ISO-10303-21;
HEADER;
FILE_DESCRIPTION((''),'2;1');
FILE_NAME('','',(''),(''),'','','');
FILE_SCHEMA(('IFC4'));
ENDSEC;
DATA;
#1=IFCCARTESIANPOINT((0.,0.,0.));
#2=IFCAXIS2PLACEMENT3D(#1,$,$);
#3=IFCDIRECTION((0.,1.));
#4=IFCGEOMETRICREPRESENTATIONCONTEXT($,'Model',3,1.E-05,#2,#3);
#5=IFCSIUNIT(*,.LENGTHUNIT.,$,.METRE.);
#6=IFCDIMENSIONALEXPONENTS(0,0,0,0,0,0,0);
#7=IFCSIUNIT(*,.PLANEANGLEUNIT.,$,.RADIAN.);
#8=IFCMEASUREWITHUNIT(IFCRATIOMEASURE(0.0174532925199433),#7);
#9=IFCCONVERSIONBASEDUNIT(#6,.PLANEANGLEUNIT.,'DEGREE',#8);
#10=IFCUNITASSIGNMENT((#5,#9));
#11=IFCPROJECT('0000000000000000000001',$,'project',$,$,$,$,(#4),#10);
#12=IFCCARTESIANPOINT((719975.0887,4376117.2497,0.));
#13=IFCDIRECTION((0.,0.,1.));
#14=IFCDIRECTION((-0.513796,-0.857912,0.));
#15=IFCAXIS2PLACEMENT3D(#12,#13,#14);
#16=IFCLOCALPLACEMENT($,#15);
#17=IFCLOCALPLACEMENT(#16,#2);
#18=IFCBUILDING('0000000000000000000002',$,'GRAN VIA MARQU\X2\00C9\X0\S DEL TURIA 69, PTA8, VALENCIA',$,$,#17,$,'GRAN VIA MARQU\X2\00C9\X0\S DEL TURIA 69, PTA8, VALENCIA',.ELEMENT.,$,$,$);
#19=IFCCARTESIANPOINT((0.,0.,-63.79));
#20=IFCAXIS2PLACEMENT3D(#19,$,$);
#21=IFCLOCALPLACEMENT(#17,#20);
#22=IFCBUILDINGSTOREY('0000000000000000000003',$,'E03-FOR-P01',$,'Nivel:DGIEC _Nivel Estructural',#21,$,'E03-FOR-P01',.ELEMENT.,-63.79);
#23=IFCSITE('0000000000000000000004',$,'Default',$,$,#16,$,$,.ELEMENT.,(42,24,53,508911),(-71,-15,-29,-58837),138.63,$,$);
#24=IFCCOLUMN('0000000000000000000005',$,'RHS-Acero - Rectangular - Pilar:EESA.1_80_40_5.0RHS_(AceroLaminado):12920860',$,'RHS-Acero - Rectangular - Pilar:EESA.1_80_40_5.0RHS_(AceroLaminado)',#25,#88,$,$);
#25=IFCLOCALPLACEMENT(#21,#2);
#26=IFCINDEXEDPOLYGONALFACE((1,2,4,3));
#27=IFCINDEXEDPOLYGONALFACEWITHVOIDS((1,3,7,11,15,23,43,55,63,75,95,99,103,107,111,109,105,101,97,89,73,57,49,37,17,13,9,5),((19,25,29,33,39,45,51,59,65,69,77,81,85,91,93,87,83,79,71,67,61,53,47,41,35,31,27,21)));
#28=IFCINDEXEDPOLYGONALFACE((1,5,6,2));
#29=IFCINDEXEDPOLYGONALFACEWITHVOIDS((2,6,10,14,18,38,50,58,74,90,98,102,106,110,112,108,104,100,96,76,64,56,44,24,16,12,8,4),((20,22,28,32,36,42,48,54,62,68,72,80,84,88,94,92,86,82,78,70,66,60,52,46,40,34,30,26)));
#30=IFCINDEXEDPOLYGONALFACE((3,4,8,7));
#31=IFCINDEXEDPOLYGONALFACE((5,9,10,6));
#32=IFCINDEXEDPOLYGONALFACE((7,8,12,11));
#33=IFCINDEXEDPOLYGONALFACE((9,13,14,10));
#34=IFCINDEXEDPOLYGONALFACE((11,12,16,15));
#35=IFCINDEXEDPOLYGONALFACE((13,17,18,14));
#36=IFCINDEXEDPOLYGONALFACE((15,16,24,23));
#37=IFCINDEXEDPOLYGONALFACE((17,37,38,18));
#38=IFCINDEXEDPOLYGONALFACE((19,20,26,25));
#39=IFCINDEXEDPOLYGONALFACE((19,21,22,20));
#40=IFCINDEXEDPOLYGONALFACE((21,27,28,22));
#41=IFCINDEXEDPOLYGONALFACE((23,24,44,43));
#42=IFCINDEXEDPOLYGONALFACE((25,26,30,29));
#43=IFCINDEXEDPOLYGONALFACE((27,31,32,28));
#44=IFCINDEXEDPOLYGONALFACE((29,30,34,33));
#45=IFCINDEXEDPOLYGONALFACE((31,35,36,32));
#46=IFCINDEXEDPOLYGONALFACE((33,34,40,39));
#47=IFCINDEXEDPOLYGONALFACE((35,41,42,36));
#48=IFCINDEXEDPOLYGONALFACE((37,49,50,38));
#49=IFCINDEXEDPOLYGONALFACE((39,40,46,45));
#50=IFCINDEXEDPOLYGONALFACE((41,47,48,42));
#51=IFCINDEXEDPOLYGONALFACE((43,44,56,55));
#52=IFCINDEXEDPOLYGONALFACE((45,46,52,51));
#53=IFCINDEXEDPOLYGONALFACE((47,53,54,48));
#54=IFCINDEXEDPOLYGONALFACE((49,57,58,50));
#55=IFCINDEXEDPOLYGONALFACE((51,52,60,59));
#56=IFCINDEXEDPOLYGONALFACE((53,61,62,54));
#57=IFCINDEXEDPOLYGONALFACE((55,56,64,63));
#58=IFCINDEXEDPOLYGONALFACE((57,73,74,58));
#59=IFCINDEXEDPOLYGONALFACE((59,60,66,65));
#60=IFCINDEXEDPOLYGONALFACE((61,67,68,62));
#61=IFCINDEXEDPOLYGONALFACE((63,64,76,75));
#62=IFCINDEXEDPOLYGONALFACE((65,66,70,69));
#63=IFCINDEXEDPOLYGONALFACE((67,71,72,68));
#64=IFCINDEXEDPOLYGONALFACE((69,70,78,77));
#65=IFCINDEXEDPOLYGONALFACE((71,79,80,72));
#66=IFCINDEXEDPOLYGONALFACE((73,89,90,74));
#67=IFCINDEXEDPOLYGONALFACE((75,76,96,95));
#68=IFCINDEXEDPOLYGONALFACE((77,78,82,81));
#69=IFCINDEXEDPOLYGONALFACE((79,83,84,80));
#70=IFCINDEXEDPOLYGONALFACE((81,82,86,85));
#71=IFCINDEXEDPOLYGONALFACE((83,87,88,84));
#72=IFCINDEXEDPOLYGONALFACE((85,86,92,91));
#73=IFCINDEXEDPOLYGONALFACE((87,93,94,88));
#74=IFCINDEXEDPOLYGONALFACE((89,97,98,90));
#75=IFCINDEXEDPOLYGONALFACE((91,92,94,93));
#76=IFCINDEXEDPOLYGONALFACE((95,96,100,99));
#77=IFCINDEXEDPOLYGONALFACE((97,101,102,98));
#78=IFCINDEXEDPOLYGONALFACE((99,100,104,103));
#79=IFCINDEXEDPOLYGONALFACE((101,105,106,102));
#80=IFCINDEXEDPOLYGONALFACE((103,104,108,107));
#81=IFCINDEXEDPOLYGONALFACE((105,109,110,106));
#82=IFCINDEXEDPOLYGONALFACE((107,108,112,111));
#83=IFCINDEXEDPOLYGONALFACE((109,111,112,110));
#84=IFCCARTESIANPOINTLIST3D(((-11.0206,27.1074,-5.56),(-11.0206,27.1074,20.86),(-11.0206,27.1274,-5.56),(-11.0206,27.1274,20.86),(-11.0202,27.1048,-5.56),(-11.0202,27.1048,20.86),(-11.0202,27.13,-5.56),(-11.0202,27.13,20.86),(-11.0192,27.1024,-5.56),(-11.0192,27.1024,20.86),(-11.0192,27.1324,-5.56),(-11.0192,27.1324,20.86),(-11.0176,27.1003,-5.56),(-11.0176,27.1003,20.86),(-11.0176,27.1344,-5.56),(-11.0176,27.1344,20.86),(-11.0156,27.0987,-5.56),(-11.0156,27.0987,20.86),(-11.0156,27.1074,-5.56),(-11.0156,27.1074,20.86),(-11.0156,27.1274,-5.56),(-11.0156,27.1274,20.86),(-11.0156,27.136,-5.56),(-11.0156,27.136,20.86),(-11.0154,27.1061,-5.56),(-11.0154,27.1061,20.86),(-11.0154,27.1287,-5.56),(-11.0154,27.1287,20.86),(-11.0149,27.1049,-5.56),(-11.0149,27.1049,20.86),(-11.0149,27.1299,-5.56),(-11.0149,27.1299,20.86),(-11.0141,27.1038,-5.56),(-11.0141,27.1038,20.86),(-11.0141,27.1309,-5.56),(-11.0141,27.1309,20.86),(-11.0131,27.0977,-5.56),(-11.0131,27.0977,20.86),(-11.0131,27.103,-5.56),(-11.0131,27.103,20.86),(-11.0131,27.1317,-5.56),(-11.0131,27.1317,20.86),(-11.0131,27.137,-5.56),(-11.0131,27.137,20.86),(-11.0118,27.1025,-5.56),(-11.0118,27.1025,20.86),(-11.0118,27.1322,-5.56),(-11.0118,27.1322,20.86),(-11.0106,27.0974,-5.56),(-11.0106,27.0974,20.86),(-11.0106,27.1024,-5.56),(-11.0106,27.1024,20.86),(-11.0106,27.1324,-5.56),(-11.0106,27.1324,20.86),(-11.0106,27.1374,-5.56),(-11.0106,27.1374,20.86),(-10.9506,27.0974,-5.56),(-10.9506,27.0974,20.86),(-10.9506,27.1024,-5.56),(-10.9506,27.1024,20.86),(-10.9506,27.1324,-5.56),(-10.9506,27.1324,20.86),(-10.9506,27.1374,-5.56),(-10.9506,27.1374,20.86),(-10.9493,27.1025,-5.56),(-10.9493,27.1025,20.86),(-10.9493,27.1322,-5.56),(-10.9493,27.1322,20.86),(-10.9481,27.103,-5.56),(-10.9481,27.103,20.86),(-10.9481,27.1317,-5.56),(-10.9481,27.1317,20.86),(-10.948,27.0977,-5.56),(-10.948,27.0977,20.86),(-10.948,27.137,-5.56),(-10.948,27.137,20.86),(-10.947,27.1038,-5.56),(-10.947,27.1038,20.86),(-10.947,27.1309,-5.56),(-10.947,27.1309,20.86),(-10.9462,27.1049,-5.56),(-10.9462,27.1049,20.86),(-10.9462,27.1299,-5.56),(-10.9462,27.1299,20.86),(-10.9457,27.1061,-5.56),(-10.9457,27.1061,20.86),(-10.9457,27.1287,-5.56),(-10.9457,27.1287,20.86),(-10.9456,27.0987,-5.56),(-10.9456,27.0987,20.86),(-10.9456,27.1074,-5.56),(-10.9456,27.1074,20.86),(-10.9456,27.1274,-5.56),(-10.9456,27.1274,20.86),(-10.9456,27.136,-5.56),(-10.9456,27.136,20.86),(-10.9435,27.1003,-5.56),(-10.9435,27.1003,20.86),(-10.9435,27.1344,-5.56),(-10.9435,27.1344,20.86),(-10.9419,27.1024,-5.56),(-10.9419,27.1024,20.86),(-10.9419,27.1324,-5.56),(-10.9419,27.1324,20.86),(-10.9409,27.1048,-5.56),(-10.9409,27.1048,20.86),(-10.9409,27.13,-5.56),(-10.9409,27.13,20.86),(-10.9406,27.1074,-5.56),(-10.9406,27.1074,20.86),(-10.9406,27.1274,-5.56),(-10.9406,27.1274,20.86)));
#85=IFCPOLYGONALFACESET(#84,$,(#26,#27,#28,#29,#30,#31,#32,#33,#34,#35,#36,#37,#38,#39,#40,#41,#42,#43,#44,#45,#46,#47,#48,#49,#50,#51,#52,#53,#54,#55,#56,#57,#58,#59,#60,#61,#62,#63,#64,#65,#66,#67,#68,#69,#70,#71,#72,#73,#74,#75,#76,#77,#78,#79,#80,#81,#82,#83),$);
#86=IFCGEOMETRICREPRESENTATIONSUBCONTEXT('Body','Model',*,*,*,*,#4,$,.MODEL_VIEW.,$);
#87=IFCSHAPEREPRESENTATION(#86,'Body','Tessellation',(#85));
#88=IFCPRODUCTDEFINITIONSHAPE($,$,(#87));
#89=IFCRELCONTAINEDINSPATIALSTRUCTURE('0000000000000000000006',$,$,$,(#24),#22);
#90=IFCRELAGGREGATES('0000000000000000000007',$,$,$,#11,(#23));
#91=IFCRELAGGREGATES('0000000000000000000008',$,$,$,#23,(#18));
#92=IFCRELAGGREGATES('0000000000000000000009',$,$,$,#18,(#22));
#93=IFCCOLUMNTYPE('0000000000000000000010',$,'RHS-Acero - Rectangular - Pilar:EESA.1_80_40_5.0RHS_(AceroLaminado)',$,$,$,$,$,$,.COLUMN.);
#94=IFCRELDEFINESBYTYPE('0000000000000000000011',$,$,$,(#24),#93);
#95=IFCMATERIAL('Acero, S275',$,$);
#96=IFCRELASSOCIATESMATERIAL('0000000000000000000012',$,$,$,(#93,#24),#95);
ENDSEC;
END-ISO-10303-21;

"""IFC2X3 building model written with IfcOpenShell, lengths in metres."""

from ifc_helpers import new_model, entity, si_unit, converted_unit, direction, frame, frame_2d, origin, place, context, subcontext, project, spatial, polyline, circle_curve, parameter, trimmed, segment, composite_curve, outline, extrude, source, transform, mapped, material, type_object, type_shapes, element, save


model = new_model("IFC2X3")

# Units and contexts
model_context = context("Model", 3, precision=1e-05, world=origin(), true_north=direction((0.0, 1.0)))
body_context = subcontext(model_context, "Body", "Model", "MODEL_VIEW")
ifc_project = project(units=[si_unit("LENGTHUNIT", "METRE"), converted_unit("PLANEANGLEUNIT", "DEGREE", entity("IfcRatioMeasure", 0.0174532925199433), si_unit("PLANEANGLEUNIT", "RADIAN"), dimensions=[0, 0, 0, 0, 0, 0, 0])], contexts=[model_context])

# Site, building, storey
site_placement = place(None, frame((719975.0887, 4376117.2497, 0.0), z_axis=(0.0, 0.0, 1.0), x_axis=(-0.513796, -0.857912, 0.0)))
site = spatial("IfcSite", under=ifc_project, at=site_placement, Name="Default", CompositionType="ELEMENT", RefLatitude=(42, 24, 53, 508911), RefLongitude=(-71, -15, -29, -58837), RefElevation=138.63)
building_placement = place(site_placement, origin())
building = spatial("IfcBuilding", under=site, at=building_placement, Name="GRAN VIA MARQUÉS DEL TURIA 69, PTA8, VALENCIA", LongName="GRAN VIA MARQUÉS DEL TURIA 69, PTA8, VALENCIA", CompositionType="ELEMENT")
storey_placement = place(building_placement, frame((0.0, 0.0, -63.79)))
storey = spatial("IfcBuildingStorey", under=building, at=storey_placement, Name="E03-FOR-P01", ObjectType="Nivel:DGIEC _Nivel Estructural", LongName="E03-FOR-P01", CompositionType="ELEMENT", Elevation=-63.79)

# Column
ifc_material_1 = material(Name="Acero, S275")
column_type_1 = type_object("IfcColumnType", Name="RHS-Acero - Rectangular - Pilar:EESA.1_80_40_5.0RHS_(AceroLaminado)", PredefinedType="COLUMN", material=ifc_material_1)
shared_shape_1 = source(origin(), body_context, "Body", "SweptSolid", [
    extrude(outline(composite_curve([segment(polyline([(-0.01, -0.04), (0.01, -0.04)]), True, "CONTINUOUS"), segment(trimmed(circle_curve(frame_2d((0.01, -0.03), x_axis=(-1.0, 0.0)), 0.01), [parameter(90.0)], [parameter(180.0)], True, "PARAMETER"), True, "CONTINUOUS"), segment(polyline([(0.02, -0.03), (0.02, 0.03)]), True, "CONTINUOUS"), segment(trimmed(circle_curve(frame_2d((0.01, 0.03), x_axis=(-1.0, 0.0)), 0.01), [parameter(180.0)], [parameter(270.0)], True, "PARAMETER"), True, "CONTINUOUS"), segment(polyline([(0.01, 0.04), (-0.01, 0.04)]), True, "CONTINUOUS"), segment(trimmed(circle_curve(frame_2d((-0.01, 0.03), x_axis=(-1.0, 0.0)), 0.01), [parameter(270.0)], [parameter(360.0)], True, "PARAMETER"), True, "CONTINUOUS"), segment(polyline([(-0.02, 0.03), (-0.02, -0.03)]), True, "CONTINUOUS"), segment(trimmed(circle_curve(frame_2d((-0.01, -0.03), x_axis=(-1.0, 0.0)), 0.01), [parameter(360.0)], [parameter(90.0)], True, "PARAMETER"), True, "CONTINUOUS")], self_intersect=False), holes=[composite_curve([segment(trimmed(circle_curve(frame_2d((-0.01, -0.03), x_axis=(-1.0, 0.0)), 0.005), [parameter(0.0)], [parameter(90.0)], True, "PARAMETER"), False, "CONTINUOUS"), segment(polyline([(-0.015, -0.03), (-0.015, 0.03)]), True, "CONTINUOUS"), segment(trimmed(circle_curve(frame_2d((-0.01, 0.03), x_axis=(-1.0, 0.0)), 0.005), [parameter(270.0)], [parameter(0.0)], True, "PARAMETER"), False, "CONTINUOUS"), segment(polyline([(-0.01, 0.035), (0.01, 0.035)]), True, "CONTINUOUS"), segment(trimmed(circle_curve(frame_2d((0.01, 0.03), x_axis=(-1.0, 0.0)), 0.005), [parameter(180.0)], [parameter(270.0)], True, "PARAMETER"), False, "CONTINUOUS"), segment(polyline([(0.015, 0.03), (0.015, -0.03)]), True, "CONTINUOUS"), segment(trimmed(circle_curve(frame_2d((0.01, -0.03), x_axis=(-1.0, 0.0)), 0.005), [parameter(90.0)], [parameter(180.0)], True, "PARAMETER"), False, "CONTINUOUS"), segment(polyline([(0.01, -0.035), (-0.01, -0.035)]), True, "CONTINUOUS")], self_intersect=False)]), frame((0.0, 0.0, -69.35), z_axis=(0.0, 0.0, 1.0), x_axis=(-1.0, 0.0, 0.0)), (0.0, 0.0, 1.0), 26.42),
])
type_shapes(column_type_1, [shared_shape_1])
for number, where, z_axis, x_axis, name in (
    (1, (-10.9806, 27.1174, 63.79), (0.0, 0.0, 1.0), (0.0, 1.0, 0.0), "RHS-Acero - Rectangular - Pilar:EESA.1_80_40_5.0RHS_(AceroLaminado):12920860"),
):
    element("IfcColumn", number, at=place(storey_placement, frame(where, z_axis=z_axis, x_axis=x_axis)), inside=storey, type_object=column_type_1, material=ifc_material_1, Name=name, ObjectType="RHS-Acero - Rectangular - Pilar:EESA.1_80_40_5.0RHS_(AceroLaminado)", context=body_context, shape_type="MappedRepresentation", body=[
        mapped(shared_shape_1, transform((0.0, 0.0, 0.0), scale=1.0)),
    ])

save(model, "model.ifc")
